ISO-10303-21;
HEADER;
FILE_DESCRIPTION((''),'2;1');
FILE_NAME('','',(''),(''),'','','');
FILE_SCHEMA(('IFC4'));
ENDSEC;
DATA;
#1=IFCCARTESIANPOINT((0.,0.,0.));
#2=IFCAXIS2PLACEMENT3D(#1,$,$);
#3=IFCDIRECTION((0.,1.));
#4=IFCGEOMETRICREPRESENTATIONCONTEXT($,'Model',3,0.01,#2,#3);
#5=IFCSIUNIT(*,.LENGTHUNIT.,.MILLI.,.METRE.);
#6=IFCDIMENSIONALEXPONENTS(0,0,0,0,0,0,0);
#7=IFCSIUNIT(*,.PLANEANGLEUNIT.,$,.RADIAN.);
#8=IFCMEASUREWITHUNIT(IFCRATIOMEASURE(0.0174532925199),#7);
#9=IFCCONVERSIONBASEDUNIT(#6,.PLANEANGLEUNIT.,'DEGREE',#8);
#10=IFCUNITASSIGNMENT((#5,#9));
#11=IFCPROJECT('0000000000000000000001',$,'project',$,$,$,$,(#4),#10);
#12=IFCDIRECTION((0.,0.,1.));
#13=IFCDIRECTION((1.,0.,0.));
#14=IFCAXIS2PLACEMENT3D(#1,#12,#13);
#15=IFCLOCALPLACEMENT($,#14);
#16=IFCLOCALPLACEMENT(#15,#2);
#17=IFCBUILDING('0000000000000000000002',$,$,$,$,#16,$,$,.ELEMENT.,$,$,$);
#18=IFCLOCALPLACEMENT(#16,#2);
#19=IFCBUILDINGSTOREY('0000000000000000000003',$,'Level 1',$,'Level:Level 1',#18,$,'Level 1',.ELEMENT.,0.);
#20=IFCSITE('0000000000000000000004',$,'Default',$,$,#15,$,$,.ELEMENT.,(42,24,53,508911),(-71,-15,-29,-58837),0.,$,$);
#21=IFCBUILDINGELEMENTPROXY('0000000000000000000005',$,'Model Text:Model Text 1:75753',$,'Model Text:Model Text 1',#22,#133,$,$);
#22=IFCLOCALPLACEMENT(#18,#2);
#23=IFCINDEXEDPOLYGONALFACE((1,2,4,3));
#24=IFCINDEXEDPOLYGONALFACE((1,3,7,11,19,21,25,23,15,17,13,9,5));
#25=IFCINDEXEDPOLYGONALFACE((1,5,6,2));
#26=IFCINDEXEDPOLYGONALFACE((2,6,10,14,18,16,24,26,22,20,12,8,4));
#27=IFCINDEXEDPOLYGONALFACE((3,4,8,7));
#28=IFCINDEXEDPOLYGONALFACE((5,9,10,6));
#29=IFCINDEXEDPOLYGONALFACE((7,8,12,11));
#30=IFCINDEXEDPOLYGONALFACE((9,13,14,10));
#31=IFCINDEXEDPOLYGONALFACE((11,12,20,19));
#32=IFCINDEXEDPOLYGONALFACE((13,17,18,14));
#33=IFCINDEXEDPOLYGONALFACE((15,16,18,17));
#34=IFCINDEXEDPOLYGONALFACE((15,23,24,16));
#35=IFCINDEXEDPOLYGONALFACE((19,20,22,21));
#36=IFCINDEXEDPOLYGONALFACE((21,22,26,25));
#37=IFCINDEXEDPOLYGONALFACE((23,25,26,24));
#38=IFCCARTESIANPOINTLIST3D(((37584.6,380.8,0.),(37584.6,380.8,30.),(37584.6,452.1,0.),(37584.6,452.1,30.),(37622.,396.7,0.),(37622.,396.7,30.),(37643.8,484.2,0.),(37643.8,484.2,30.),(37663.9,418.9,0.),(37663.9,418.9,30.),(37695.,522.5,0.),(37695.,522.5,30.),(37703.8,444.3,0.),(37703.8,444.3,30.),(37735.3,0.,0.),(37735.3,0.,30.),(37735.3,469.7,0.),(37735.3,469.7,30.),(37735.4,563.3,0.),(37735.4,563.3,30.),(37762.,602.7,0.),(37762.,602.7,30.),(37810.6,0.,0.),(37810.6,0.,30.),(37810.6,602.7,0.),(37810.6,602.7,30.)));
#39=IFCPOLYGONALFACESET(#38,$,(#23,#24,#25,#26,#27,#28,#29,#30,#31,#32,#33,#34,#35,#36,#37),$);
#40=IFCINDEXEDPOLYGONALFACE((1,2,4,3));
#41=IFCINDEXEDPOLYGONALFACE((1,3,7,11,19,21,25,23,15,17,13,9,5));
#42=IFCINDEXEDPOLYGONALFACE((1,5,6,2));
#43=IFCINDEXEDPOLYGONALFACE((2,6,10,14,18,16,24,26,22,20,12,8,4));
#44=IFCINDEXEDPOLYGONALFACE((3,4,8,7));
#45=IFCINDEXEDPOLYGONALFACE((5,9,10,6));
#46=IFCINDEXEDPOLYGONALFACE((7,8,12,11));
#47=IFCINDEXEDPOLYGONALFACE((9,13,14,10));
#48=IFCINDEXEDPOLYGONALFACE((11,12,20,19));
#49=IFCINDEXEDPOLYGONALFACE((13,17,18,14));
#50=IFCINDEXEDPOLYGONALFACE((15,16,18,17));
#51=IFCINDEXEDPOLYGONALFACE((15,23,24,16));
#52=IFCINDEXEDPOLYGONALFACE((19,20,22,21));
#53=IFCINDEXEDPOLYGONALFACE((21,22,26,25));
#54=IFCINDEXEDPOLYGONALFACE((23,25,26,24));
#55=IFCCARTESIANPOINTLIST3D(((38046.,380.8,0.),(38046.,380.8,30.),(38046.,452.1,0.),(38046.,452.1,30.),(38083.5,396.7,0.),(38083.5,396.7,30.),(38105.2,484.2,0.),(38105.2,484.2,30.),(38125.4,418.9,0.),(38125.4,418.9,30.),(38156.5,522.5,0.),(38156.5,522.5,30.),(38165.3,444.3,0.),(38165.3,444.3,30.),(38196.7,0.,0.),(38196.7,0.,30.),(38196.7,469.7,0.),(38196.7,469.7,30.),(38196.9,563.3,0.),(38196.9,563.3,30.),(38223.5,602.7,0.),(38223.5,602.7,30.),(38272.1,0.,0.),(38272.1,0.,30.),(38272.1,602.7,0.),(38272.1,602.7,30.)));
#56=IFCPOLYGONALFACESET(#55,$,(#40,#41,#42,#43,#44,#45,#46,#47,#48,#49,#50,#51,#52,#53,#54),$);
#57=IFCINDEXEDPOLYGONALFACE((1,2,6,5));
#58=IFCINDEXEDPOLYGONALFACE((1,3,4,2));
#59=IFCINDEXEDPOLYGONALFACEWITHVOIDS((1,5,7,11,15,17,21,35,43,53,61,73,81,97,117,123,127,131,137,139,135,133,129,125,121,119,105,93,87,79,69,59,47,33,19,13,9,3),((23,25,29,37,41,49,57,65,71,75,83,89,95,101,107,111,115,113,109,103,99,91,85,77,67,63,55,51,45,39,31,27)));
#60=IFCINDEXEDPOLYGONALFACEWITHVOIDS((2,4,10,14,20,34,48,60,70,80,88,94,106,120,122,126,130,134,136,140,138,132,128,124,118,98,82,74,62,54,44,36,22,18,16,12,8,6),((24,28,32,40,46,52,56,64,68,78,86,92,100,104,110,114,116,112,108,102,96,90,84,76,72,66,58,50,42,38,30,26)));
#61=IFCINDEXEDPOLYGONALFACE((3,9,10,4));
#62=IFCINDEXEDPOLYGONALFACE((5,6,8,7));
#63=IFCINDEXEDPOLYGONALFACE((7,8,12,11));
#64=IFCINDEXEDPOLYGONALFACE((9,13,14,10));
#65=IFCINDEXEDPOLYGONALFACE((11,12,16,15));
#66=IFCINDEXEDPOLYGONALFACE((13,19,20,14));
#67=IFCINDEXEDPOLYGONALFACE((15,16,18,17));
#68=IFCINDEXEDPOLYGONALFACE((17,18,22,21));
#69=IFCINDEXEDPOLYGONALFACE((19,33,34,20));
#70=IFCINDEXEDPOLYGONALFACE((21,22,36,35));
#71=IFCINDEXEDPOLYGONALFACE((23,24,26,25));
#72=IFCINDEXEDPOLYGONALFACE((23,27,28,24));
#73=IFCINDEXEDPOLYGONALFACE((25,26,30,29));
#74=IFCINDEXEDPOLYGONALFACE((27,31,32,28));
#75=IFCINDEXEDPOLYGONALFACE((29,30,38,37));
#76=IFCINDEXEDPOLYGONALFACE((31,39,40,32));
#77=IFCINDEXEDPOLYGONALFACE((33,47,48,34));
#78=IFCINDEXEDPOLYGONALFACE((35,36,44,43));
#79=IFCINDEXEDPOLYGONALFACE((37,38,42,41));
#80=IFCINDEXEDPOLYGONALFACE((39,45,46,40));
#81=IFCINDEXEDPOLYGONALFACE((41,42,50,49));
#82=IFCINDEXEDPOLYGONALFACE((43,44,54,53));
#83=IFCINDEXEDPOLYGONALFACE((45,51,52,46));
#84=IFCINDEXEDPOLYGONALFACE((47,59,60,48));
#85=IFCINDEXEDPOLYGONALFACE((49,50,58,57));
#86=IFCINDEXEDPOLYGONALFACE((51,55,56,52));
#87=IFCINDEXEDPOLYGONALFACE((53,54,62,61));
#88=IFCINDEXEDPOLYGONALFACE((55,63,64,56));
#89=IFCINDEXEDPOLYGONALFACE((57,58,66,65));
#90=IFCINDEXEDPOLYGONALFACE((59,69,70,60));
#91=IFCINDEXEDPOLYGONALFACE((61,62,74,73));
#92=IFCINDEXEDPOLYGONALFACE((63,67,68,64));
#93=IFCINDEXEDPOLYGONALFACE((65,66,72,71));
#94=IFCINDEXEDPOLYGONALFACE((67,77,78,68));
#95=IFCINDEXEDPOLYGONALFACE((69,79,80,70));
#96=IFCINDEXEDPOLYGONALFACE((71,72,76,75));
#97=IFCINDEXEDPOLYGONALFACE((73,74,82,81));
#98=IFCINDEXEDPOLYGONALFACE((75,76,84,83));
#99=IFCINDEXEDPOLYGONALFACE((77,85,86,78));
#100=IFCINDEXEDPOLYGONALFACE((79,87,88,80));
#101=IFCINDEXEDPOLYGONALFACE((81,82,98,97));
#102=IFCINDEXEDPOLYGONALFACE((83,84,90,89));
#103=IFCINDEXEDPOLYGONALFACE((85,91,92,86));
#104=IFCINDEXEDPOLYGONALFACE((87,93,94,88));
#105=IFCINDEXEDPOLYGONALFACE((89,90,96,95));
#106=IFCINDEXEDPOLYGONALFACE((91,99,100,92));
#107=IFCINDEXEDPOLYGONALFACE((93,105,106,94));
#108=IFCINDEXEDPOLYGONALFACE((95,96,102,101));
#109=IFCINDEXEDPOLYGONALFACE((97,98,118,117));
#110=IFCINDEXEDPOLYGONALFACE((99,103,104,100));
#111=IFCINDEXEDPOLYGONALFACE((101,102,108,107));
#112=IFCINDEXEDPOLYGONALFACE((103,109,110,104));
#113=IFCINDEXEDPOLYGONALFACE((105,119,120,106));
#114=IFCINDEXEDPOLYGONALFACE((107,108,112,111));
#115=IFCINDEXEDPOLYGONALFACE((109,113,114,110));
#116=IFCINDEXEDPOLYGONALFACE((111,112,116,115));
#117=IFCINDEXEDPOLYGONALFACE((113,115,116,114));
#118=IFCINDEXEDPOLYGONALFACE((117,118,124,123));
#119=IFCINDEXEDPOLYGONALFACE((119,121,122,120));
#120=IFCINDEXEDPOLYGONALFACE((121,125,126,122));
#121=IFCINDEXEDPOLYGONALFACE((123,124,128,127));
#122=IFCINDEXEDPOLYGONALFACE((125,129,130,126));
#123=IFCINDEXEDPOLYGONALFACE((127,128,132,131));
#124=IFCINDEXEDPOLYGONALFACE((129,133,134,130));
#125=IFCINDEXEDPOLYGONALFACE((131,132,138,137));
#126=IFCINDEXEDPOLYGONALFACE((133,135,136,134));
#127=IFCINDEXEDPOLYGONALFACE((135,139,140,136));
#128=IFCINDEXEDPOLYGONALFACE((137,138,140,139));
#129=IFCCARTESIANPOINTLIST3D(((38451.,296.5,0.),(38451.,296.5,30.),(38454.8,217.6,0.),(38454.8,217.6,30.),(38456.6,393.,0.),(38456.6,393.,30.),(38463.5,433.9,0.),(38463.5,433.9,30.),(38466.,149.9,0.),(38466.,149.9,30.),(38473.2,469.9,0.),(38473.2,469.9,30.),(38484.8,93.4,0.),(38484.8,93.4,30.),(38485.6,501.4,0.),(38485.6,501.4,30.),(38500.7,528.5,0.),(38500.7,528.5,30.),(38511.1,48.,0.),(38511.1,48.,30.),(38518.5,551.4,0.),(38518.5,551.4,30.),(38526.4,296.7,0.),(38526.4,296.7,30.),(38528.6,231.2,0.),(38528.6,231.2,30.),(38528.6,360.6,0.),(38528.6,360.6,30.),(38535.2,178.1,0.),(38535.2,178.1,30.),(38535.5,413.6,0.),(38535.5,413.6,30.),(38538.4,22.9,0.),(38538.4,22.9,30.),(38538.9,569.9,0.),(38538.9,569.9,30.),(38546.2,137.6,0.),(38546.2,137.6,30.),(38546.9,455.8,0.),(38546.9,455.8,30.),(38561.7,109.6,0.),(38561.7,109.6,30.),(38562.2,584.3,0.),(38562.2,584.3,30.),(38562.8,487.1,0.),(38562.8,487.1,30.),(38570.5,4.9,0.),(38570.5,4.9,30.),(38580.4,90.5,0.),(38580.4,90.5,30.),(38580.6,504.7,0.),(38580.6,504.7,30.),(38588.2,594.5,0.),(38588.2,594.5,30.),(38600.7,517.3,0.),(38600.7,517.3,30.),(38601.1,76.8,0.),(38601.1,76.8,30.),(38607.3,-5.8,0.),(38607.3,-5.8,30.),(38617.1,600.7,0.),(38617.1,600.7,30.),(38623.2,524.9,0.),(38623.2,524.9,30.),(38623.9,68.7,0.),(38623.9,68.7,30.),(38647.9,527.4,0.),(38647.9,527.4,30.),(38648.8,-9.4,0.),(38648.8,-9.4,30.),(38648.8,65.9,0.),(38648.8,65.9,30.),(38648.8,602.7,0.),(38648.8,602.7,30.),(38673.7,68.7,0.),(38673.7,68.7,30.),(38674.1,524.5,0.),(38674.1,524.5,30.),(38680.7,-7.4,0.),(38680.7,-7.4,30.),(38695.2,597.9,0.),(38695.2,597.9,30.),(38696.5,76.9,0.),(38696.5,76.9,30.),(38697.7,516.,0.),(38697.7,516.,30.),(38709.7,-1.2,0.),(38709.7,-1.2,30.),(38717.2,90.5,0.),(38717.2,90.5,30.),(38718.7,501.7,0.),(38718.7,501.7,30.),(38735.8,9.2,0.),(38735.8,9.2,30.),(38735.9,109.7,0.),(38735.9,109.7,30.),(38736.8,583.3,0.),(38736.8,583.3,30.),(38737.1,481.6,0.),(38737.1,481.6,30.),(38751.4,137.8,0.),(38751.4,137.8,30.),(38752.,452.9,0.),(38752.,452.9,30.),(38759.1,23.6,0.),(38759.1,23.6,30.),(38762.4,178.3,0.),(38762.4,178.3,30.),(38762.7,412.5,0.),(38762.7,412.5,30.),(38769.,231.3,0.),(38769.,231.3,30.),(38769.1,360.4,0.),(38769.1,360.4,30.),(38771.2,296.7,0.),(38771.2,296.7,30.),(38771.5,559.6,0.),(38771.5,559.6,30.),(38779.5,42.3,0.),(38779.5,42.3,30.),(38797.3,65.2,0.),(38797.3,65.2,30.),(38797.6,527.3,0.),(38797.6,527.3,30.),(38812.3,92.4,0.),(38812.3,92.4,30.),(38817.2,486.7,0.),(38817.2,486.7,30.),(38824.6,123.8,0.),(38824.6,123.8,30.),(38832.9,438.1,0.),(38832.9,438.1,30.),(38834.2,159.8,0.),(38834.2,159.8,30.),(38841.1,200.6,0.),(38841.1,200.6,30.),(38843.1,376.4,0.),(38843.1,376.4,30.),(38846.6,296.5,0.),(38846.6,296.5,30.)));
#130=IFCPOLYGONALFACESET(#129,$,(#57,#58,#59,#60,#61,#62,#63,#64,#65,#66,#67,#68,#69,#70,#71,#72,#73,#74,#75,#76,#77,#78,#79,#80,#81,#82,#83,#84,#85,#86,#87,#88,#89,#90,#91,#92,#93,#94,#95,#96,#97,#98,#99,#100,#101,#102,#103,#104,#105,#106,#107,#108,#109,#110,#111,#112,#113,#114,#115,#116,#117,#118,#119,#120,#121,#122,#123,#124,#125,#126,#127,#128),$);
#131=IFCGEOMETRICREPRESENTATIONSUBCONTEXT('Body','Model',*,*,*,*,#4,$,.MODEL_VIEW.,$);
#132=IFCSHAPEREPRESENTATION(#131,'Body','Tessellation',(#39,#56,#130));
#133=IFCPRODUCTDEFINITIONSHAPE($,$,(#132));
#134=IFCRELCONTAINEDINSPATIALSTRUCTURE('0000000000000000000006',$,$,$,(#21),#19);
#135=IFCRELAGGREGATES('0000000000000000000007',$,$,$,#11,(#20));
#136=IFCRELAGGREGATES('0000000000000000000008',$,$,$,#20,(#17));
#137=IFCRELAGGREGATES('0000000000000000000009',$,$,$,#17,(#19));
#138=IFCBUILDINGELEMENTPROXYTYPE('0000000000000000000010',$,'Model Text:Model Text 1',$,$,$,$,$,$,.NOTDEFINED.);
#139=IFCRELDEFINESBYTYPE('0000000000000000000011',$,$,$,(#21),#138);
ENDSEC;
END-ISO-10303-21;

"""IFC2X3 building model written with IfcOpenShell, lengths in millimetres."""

from ifc_helpers import new_model, entity, si_unit, converted_unit, direction, frame, origin, origin_with_axes, place, context, subcontext, project, spatial, polyline, outline, extrude, type_object, element, save


model = new_model("IFC2X3")

# Units and contexts
model_context = context("Model", 3, precision=0.01, world=origin(), true_north=direction((0.0, 1.0)))
body_context = subcontext(model_context, "Body", "Model", "MODEL_VIEW")
ifc_project = project(units=[si_unit("LENGTHUNIT", "METRE", prefix="MILLI"), converted_unit("PLANEANGLEUNIT", "DEGREE", entity("IfcRatioMeasure", 0.0174532925199), si_unit("PLANEANGLEUNIT", "RADIAN"), dimensions=[0, 0, 0, 0, 0, 0, 0])], contexts=[model_context])

# Site, building, storey
site_placement = place(None, origin_with_axes())
site = spatial("IfcSite", under=ifc_project, at=site_placement, Name="Default", CompositionType="ELEMENT", RefLatitude=(42, 24, 53, 508911), RefLongitude=(-71, -15, -29, -58837), RefElevation=0.0)
building_placement = place(site_placement, origin())
building = spatial("IfcBuilding", under=site, at=building_placement, CompositionType="ELEMENT")
storey_placement = place(building_placement, origin())
storey = spatial("IfcBuildingStorey", under=building, at=storey_placement, Name="Level 1", ObjectType="Level:Level 1", LongName="Level 1", CompositionType="ELEMENT", Elevation=0.0)

# Building element proxy
building_element_proxy_type_1 = type_object("IfcBuildingElementProxyType", Name="Model Text:Model Text 1", PredefinedType="NOTDEFINED")
proxy_1_placement = place(storey_placement, frame((37584.6, -9.4, 0.0)))
element("IfcBuildingElementProxy", 1, at=proxy_1_placement, inside=storey, type_object=building_element_proxy_type_1, Name="Model Text:Model Text 1:75753", ObjectType="Model Text:Model Text 1", context=body_context, shape_type="SweptSolid", body=[
    extrude(outline(polyline([(-410.6, -111.6), (192.1, -111.6), (192.1, -63.1), (152.7, -36.4), (111.9, 4.0), (73.6, 55.2), (41.4, 114.4), (-29.8, 114.4), (-13.9, 77.0), (8.3, 35.1), (33.7, -4.8), (59.1, -36.3), (-410.6, -36.3), (-410.6, -111.6)])), frame((114.4, 420.0, 0.0), z_axis=(0.0, 0.0, 1.0), x_axis=(0.0, 1.0, 0.0)), (0.0, 0.0, 1.0), 30.0),
    extrude(outline(polyline([(-410.6, -111.6), (192.1, -111.6), (192.1, -63.1), (152.7, -36.4), (111.9, 4.0), (73.6, 55.2), (41.4, 114.4), (-29.8, 114.4), (-13.9, 77.0), (8.3, 35.1), (33.7, -4.8), (59.1, -36.3), (-410.6, -36.3), (-410.6, -111.6)])), frame((575.9, 420.0, 0.0), z_axis=(0.0, 0.0, 1.0), x_axis=(0.0, 1.0, 0.0)), (0.0, 0.0, 1.0), 30.0),
    extrude(outline(polyline([(-10.6, -198.7), (68.3, -198.7), (136.5, -190.7), (193.9, -174.7), (240.5, -150.6), (266.9, -124.4), (286.3, -93.2), (298.8, -57.0), (304.3, -15.7), (303.8, 16.2), (299.0, 45.5), (289.9, 72.1), (276.6, 96.0), (258.9, 117.3), (236.9, 136.2), (210.4, 152.5), (179.6, 166.3), (144.1, 177.6), (103.7, 186.3), (8.2, 196.4), (-71.8, 196.7), (-134.0, 189.4), (-183.3, 176.1), (-224.7, 158.4), (-258.2, 133.9), (-283.5, 100.3), (-300.1, 59.5), (-307.1, 13.4), (-306.6, -18.4), (-301.8, -47.5), (-292.8, -74.0), (-279.6, -97.9), (-262.0, -119.2), (-240.0, -138.1), (-213.6, -154.5), (-182.8, -168.4), (-147.3, -179.8), (-106.7, -188.6), (-10.6, -198.7)]), holes=[polyline([(-7.2, -123.5), (-71.0, -118.2), (-123.6, -108.8), (-165.2, -95.4), (-195.7, -78.0), (-212.4, -59.4), (-224.1, -38.7), (-230.6, -15.9), (-231.9, 8.9), (-227.8, 35.0), (-218.1, 58.1), (-202.8, 78.4), (-182.0, 95.8), (-152.6, 109.4), (-111.7, 118.1), (-59.4, 122.0), (4.4, 121.1), (69.6, 115.8), (122.2, 106.7), (162.2, 93.7), (189.5, 77.0), (207.7, 57.4), (220.4, 36.0), (227.5, 12.8), (229.1, -12.1), (225.2, -36.8), (215.9, -59.2), (201.3, -79.3), (181.4, -97.1), (152.6, -111.2), (111.6, -120.3), (58.3, -124.4), (-7.2, -123.5)])]), frame((1065.4, 304.7, 0.0), z_axis=(0.0, 0.0, 1.0), x_axis=(0.047515, -0.998871, 0.0)), (0.0, 0.0, 1.0), 30.0),
])

save(model, "model.ifc")
